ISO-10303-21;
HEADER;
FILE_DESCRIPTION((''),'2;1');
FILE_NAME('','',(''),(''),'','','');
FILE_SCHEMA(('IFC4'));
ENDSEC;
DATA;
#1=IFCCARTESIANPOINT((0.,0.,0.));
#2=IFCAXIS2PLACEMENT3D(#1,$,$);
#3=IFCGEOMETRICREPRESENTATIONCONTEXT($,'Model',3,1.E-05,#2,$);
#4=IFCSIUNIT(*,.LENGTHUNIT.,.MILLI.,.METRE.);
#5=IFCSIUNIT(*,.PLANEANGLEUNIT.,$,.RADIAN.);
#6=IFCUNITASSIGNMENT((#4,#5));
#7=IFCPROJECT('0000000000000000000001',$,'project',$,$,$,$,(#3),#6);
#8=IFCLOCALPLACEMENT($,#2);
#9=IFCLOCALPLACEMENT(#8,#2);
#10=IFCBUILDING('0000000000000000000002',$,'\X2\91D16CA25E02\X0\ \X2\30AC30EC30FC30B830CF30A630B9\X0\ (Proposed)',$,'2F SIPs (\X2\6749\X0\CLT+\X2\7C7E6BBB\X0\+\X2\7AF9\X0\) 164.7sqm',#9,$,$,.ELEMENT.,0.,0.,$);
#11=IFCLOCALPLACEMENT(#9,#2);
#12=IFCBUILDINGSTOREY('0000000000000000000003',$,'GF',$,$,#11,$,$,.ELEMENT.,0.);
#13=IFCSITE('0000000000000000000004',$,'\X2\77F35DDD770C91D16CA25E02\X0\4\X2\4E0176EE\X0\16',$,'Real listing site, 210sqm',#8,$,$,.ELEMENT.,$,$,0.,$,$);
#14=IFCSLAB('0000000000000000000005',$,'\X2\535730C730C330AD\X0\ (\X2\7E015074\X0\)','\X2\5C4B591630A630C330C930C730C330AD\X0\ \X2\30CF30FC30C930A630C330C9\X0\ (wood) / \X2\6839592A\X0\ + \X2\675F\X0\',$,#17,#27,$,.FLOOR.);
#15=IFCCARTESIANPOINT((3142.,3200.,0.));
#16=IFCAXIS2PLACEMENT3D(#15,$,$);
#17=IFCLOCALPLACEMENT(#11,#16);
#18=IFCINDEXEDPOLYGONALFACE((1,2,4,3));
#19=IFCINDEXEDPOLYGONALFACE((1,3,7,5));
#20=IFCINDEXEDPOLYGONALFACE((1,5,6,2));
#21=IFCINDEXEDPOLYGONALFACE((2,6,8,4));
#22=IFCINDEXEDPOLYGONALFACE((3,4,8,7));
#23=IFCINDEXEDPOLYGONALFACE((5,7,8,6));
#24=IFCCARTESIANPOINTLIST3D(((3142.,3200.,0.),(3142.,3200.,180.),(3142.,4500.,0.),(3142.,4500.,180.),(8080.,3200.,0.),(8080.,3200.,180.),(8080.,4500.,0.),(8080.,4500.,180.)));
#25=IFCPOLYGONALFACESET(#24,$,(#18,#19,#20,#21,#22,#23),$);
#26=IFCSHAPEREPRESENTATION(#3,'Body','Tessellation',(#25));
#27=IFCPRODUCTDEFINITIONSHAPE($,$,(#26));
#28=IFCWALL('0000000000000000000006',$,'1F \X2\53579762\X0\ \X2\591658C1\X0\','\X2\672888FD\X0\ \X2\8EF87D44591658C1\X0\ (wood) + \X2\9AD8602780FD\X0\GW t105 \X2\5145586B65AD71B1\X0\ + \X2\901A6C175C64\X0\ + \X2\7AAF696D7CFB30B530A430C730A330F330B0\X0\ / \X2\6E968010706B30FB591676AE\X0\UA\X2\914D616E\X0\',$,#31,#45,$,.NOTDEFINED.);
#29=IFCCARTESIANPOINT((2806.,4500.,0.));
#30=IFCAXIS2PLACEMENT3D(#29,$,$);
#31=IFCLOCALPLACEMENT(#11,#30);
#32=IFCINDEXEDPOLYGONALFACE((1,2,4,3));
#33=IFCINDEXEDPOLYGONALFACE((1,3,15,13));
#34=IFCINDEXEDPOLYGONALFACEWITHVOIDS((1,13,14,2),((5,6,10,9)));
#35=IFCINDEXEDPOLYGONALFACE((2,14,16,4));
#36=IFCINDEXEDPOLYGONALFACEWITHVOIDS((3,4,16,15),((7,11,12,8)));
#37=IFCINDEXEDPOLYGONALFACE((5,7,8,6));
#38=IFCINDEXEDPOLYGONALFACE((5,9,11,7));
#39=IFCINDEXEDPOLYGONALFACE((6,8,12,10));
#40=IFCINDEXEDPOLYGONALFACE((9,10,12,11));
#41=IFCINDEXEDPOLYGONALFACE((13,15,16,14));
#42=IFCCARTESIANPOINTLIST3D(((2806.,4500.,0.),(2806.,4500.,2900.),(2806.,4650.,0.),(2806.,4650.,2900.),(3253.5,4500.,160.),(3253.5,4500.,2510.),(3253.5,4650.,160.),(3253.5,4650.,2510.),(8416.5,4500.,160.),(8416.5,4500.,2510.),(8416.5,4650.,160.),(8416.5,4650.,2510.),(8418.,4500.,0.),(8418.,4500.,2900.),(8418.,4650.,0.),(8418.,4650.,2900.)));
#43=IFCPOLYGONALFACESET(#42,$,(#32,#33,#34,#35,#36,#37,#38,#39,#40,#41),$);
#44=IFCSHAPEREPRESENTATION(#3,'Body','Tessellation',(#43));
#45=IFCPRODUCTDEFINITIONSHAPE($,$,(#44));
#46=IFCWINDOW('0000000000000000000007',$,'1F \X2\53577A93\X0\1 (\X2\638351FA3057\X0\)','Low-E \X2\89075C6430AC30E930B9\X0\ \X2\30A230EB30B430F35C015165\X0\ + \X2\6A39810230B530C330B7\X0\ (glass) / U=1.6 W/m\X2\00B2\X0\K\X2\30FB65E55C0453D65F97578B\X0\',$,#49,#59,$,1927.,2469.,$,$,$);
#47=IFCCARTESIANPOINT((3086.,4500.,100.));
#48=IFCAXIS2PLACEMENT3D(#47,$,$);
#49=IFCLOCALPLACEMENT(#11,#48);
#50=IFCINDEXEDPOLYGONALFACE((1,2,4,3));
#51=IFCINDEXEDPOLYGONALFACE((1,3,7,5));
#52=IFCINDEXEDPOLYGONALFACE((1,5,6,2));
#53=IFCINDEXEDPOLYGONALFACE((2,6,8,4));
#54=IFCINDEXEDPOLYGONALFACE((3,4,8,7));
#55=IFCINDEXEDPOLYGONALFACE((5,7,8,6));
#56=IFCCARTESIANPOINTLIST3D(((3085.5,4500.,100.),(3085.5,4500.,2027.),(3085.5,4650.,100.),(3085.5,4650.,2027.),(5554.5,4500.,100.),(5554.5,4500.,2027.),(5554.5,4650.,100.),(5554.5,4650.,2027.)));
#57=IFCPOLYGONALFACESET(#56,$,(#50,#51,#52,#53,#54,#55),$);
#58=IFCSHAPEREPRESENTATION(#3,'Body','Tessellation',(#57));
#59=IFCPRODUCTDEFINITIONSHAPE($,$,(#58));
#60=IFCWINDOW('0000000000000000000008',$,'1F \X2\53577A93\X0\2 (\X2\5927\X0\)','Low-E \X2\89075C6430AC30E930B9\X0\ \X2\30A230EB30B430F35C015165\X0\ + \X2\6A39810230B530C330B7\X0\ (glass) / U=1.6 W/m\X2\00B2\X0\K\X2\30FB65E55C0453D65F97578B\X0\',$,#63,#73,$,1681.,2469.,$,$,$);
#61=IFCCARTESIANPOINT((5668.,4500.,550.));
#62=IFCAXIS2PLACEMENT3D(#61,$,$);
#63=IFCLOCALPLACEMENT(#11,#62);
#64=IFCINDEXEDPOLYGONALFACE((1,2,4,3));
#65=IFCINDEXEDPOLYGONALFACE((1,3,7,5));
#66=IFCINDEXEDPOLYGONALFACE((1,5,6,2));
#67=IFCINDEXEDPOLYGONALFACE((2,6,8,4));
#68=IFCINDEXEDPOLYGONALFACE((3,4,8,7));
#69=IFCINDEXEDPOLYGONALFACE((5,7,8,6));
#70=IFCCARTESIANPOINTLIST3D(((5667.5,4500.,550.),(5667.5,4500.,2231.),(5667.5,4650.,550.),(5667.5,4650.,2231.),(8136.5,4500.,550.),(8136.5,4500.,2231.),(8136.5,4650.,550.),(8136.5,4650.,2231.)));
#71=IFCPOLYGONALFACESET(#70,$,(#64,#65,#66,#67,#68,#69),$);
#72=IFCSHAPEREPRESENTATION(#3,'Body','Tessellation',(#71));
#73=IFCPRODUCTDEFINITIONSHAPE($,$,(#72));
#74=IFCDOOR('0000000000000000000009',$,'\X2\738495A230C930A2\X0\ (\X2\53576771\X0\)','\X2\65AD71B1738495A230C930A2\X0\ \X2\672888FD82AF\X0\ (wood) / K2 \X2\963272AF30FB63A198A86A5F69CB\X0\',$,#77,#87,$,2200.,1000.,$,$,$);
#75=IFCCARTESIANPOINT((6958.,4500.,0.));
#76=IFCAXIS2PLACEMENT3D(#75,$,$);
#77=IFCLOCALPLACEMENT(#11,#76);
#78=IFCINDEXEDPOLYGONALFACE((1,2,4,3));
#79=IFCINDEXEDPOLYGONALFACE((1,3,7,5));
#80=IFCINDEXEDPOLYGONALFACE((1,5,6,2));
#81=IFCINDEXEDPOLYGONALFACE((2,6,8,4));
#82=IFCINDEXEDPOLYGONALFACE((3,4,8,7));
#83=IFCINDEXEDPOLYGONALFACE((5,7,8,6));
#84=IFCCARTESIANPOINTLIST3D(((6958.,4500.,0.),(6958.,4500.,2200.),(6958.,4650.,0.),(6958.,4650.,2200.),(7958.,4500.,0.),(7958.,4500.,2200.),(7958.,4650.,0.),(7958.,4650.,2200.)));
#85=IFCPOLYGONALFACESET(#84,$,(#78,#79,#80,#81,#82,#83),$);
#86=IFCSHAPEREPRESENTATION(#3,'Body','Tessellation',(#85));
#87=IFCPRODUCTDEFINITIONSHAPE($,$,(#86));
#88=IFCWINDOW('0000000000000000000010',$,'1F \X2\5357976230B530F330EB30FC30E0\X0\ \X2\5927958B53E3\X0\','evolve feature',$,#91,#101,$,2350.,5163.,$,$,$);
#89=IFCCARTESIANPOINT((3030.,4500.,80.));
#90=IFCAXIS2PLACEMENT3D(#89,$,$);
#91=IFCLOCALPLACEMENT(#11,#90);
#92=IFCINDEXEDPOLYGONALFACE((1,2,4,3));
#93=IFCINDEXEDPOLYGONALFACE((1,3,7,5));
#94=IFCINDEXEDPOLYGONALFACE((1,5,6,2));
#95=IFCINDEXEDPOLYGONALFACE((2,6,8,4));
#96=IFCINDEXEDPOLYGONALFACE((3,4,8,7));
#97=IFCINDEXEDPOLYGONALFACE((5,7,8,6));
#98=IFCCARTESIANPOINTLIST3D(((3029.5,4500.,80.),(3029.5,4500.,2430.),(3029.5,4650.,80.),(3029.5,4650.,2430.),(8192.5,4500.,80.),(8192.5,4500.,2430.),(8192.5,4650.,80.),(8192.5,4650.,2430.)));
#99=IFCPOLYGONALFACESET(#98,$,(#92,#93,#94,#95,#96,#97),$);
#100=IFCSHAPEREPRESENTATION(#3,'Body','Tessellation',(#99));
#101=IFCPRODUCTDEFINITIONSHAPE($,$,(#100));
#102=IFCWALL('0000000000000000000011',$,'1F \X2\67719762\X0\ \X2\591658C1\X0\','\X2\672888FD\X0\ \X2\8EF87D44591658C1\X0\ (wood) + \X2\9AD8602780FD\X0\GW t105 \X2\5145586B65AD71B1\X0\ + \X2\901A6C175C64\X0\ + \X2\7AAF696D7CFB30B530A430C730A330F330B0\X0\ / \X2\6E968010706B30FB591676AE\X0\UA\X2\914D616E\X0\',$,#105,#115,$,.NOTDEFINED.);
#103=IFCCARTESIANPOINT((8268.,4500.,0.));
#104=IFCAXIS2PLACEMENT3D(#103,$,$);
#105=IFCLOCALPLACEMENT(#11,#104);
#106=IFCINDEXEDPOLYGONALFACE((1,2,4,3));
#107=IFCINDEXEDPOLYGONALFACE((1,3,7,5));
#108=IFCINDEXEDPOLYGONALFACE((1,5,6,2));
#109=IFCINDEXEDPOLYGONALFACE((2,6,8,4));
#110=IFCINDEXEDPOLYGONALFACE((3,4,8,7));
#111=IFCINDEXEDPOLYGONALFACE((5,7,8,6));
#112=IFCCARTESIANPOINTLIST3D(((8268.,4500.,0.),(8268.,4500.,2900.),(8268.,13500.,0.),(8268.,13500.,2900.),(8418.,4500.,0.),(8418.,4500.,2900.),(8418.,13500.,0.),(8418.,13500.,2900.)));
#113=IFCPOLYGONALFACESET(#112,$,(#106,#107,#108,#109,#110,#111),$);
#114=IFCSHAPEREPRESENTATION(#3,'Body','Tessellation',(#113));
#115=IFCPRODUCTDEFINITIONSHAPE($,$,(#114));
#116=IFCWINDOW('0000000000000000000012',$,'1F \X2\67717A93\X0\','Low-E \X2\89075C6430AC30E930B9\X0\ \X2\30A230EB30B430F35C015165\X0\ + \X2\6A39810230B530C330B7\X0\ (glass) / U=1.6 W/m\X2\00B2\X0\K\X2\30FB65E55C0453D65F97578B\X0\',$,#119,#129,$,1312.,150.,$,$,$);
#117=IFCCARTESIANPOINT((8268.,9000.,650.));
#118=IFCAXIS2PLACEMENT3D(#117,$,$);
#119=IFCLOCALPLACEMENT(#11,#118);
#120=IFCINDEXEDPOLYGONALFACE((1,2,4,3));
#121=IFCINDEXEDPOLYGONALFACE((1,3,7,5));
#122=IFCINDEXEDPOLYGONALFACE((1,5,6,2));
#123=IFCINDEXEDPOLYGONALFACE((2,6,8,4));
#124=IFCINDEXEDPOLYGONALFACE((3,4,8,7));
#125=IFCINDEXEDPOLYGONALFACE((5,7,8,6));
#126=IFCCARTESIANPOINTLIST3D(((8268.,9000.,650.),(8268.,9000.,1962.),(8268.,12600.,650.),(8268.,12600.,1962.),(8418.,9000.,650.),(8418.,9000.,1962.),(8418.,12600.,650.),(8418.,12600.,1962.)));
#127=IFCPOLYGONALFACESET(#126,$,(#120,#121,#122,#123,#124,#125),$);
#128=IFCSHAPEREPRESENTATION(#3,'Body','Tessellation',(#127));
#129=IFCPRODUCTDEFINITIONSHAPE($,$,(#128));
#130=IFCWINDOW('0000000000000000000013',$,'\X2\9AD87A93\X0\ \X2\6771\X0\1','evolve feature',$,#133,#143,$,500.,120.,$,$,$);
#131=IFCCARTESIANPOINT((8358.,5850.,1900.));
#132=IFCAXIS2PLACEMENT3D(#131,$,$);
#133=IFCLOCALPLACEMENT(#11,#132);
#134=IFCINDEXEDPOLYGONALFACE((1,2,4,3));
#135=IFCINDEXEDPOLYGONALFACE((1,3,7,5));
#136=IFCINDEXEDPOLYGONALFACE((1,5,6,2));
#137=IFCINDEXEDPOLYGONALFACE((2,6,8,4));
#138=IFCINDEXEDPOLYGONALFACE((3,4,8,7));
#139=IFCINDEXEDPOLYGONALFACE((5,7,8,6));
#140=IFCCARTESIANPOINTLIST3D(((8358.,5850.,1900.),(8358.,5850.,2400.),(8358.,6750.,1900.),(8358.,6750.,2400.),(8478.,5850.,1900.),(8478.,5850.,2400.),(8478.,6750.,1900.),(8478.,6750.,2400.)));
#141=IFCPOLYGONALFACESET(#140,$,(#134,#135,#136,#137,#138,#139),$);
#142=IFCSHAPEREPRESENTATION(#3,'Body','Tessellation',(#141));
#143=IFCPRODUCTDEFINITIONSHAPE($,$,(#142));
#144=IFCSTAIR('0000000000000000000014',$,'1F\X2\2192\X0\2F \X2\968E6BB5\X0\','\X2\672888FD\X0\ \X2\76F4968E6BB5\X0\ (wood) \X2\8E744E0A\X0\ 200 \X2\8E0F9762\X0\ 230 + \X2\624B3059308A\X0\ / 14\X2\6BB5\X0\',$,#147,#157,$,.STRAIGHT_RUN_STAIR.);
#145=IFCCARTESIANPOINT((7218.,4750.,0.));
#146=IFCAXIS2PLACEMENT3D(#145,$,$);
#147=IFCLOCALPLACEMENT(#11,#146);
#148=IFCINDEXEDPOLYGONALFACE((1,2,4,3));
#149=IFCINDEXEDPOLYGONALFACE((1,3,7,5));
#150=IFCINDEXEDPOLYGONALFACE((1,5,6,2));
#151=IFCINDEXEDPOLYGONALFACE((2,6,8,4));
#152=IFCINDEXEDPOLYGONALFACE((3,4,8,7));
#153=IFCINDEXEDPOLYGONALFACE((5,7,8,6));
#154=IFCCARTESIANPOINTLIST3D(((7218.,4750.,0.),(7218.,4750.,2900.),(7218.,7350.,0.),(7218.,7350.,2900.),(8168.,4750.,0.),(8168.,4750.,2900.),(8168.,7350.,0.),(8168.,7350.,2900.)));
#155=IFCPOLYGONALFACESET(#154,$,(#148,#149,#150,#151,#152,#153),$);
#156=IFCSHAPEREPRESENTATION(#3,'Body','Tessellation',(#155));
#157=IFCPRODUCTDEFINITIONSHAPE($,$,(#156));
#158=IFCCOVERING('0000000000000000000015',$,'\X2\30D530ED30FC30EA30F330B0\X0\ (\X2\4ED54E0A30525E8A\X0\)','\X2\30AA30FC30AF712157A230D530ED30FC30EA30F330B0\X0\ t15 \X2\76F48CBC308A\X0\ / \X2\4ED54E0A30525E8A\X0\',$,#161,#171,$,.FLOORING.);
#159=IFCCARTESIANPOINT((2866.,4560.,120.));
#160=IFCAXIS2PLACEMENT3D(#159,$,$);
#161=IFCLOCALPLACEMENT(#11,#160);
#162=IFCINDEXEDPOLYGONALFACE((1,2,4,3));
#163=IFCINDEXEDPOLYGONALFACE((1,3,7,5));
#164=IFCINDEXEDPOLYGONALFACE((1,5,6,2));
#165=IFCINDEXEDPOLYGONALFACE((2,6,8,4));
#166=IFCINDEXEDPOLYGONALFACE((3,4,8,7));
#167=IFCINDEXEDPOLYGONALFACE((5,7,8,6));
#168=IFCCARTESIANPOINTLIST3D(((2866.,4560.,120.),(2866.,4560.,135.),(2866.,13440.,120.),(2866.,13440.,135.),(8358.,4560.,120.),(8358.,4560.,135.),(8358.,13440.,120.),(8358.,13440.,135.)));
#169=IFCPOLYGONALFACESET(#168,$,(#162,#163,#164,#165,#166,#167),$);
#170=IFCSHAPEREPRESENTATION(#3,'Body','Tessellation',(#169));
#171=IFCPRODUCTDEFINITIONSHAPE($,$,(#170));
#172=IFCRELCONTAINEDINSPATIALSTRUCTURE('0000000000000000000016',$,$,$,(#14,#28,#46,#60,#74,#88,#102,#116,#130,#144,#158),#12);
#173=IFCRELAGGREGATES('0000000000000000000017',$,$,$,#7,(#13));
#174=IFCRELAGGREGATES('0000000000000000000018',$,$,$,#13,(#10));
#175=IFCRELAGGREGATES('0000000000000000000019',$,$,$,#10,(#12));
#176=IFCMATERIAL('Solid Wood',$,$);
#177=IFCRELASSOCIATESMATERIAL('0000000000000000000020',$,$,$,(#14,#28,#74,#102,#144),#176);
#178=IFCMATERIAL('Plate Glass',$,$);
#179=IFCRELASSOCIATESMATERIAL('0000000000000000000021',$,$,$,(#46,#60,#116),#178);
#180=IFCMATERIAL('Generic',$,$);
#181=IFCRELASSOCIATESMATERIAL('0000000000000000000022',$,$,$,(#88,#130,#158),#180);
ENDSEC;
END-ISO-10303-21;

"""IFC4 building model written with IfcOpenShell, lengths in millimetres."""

from ifc_helpers import new_model, si_unit, frame, frame_2d, origin, place, context, project, spatial, rectangle, extrude, material, element, fill, save


model = new_model("IFC4")

# Units and contexts
model_context = context("Model", 3, precision=1e-05, world=origin())
ifc_project = project(units=[si_unit("LENGTHUNIT", "METRE", prefix="MILLI"), si_unit("PLANEANGLEUNIT", "RADIAN")], contexts=[model_context])

# Site, building, storey
site_placement = place(None, origin())
site = spatial("IfcSite", under=ifc_project, at=site_placement, Name="石川県金沢市4丁目16", ObjectType="Real listing site, 210sqm", CompositionType="ELEMENT", RefElevation=0.0)
building_placement = place(site_placement, origin())
building = spatial("IfcBuilding", under=site, at=building_placement, Name="金沢市 ガレージハウス (Proposed)", ObjectType="2F SIPs (杉CLT+籾殻+竹) 164.7sqm", CompositionType="ELEMENT", ElevationOfRefHeight=0.0, ElevationOfTerrain=0.0)
storey_placement = place(building_placement, origin())
storey = spatial("IfcBuildingStorey", under=building, at=storey_placement, Name="GF", CompositionType="ELEMENT", Elevation=0.0)

# Slab
ifc_material_1 = material(Name="Solid Wood")
slab_1_placement = place(storey_placement, frame((3142.0, 3200.0, 0.0)))
element("IfcSlab", 1, at=slab_1_placement, inside=storey, material=ifc_material_1, Name="南デッキ (縁側)", Description="屋外ウッドデッキ ハードウッド (wood) / 根太 + 束", PredefinedType="FLOOR", context=model_context, shape_type="SweptSolid", body=[
    extrude(rectangle(XDim=4938.0, YDim=1300.0, at=frame_2d((2469.0, 650.0))), frame((3142.0, 3200.0, 0.0)), (0.0, 0.0, 1.0), 180.0),
])
ifc_material_2 = material(Name="Generic")

# Wall, openings, windows, door
wall_1_placement = place(storey_placement, frame((2806.0, 4500.0, 0.0)))
wall_1 = element("IfcWall", 2, at=wall_1_placement, inside=storey, material=ifc_material_1, Name="1F 南面 外壁", Description="木製 軸組外壁 (wood) + 高性能GW t105 充填断熱 + 通気層 + 窯業系サイディング / 準耐火・外皮UA配慮", PredefinedType="NOTDEFINED", context=model_context, shape_type="SweptSolid", body=[
    extrude(rectangle(XDim=5612.0, YDim=150.0, at=frame_2d((2806.0, 75.0))), frame((2806.0, 4500.0, 0.0)), (0.0, 0.0, 1.0), 2900.0),
])
opening_1_placement = place(storey_placement, frame((3086.0, 4500.0, 100.0)))
opening_1 = element("IfcOpeningElement", 3, at=opening_1_placement, cuts=wall_1, PredefinedType="NOTDEFINED", context=model_context, shape_type="SweptSolid", body=[
    extrude(rectangle(XDim=2469.0, YDim=150.0, at=frame_2d((1234.0, 75.0))), frame((3086.0, 4500.0, 100.0)), (0.0, 0.0, 1.0), 1927.0),
])
opening_2_placement = place(storey_placement, frame((5668.0, 4500.0, 550.0)))
opening_2 = element("IfcOpeningElement", 4, at=opening_2_placement, cuts=wall_1, PredefinedType="NOTDEFINED", context=model_context, shape_type="SweptSolid", body=[
    extrude(rectangle(XDim=2469.0, YDim=150.0, at=frame_2d((1234.0, 75.0))), frame((5668.0, 4500.0, 550.0)), (0.0, 0.0, 1.0), 1681.0),
])
opening_3_placement = place(storey_placement, frame((6958.0, 4500.0, 0.0)))
opening_3 = element("IfcOpeningElement", 5, at=opening_3_placement, cuts=wall_1, PredefinedType="NOTDEFINED", context=model_context, shape_type="SweptSolid", body=[
    extrude(rectangle(XDim=1000.0, YDim=150.0, at=frame_2d((500.0, 75.0))), frame((6958.0, 4500.0, 0.0)), (0.0, 0.0, 1.0), 2200.0),
])
opening_4_placement = place(storey_placement, frame((3030.0, 4500.0, 80.0)))
opening_4 = element("IfcOpeningElement", 6, at=opening_4_placement, cuts=wall_1, PredefinedType="NOTDEFINED", context=model_context, shape_type="SweptSolid", body=[
    extrude(rectangle(XDim=5163.0, YDim=150.0, at=frame_2d((2581.0, 75.0))), frame((3030.0, 4500.0, 80.0)), (0.0, 0.0, 1.0), 2350.0),
])
ifc_material_3 = material(Name="Plate Glass")
window_1_placement = place(storey_placement, frame((3086.0, 4500.0, 100.0)))
window_1 = element("IfcWindow", 7, at=window_1_placement, inside=storey, material=ifc_material_3, Name="1F 南窓1 (掃出し)", Description="Low-E 複層ガラス アルゴン封入 + 樹脂サッシ (glass) / U=1.6 W/m²K・日射取得型", OverallHeight=1927.0, OverallWidth=2469.0, context=model_context, shape_type="SweptSolid", body=[
    extrude(rectangle(XDim=2469.0, YDim=150.0, at=frame_2d((1234.0, 75.0))), frame((3086.0, 4500.0, 100.0)), (0.0, 0.0, 1.0), 1927.0),
])
fill(opening_1, window_1)
window_2_placement = place(storey_placement, frame((5668.0, 4500.0, 550.0)))
window_2 = element("IfcWindow", 8, at=window_2_placement, inside=storey, material=ifc_material_3, Name="1F 南窓2 (大)", Description="Low-E 複層ガラス アルゴン封入 + 樹脂サッシ (glass) / U=1.6 W/m²K・日射取得型", OverallHeight=1681.0, OverallWidth=2469.0, context=model_context, shape_type="SweptSolid", body=[
    extrude(rectangle(XDim=2469.0, YDim=150.0, at=frame_2d((1234.0, 75.0))), frame((5668.0, 4500.0, 550.0)), (0.0, 0.0, 1.0), 1681.0),
])
fill(opening_2, window_2)
door_placement = place(storey_placement, frame((6958.0, 4500.0, 0.0)))
door = element("IfcDoor", 9, at=door_placement, inside=storey, material=ifc_material_1, Name="玄関ドア (南東)", Description="断熱玄関ドア 木製芯 (wood) / K2 防犯・採風機構", OverallHeight=2200.0, OverallWidth=1000.0, context=model_context, shape_type="SweptSolid", body=[
    extrude(rectangle(XDim=1000.0, YDim=150.0, at=frame_2d((500.0, 75.0))), frame((6958.0, 4500.0, 0.0)), (0.0, 0.0, 1.0), 2200.0),
])
fill(opening_3, door)
window_3_placement = place(storey_placement, frame((3030.0, 4500.0, 80.0)))
window_3 = element("IfcWindow", 10, at=window_3_placement, inside=storey, material=ifc_material_2, Name="1F 南面サンルーム 大開口", Description="evolve feature", OverallHeight=2350.0, OverallWidth=5163.0, context=model_context, shape_type="SweptSolid", body=[
    extrude(rectangle(XDim=5163.0, YDim=150.0, at=frame_2d((2581.0, 75.0))), frame((3030.0, 4500.0, 80.0)), (0.0, 0.0, 1.0), 2350.0),
])
fill(opening_4, window_3)

# Wall, openings, windows
wall_2_placement = place(storey_placement, frame((8268.0, 4500.0, 0.0)))
wall_2 = element("IfcWall", 11, at=wall_2_placement, inside=storey, material=ifc_material_1, Name="1F 東面 外壁", Description="木製 軸組外壁 (wood) + 高性能GW t105 充填断熱 + 通気層 + 窯業系サイディング / 準耐火・外皮UA配慮", PredefinedType="NOTDEFINED", context=model_context, shape_type="SweptSolid", body=[
    extrude(rectangle(XDim=150.0, YDim=9000.0, at=frame_2d((75.0, 4500.0))), frame((8268.0, 4500.0, 0.0)), (0.0, 0.0, 1.0), 2900.0),
])
opening_5_placement = place(storey_placement, frame((8268.0, 9000.0, 650.0)))
opening_5 = element("IfcOpeningElement", 12, at=opening_5_placement, cuts=wall_2, PredefinedType="NOTDEFINED", context=model_context, shape_type="SweptSolid", body=[
    extrude(rectangle(XDim=150.0, YDim=3600.0, at=frame_2d((75.0, 1800.0))), frame((8268.0, 9000.0, 650.0)), (0.0, 0.0, 1.0), 1312.0),
])
opening_6_placement = place(storey_placement, frame((8358.0, 5850.0, 1900.0)))
opening_6 = element("IfcOpeningElement", 13, at=opening_6_placement, cuts=wall_2, PredefinedType="NOTDEFINED", context=model_context, shape_type="SweptSolid", body=[
    extrude(rectangle(XDim=120.0, YDim=900.0, at=frame_2d((60.0, 450.0))), frame((8358.0, 5850.0, 1900.0)), (0.0, 0.0, 1.0), 500.0),
])
window_4_placement = place(storey_placement, frame((8268.0, 9000.0, 650.0)))
window_4 = element("IfcWindow", 14, at=window_4_placement, inside=storey, material=ifc_material_3, Name="1F 東窓", Description="Low-E 複層ガラス アルゴン封入 + 樹脂サッシ (glass) / U=1.6 W/m²K・日射取得型", OverallHeight=1312.0, OverallWidth=150.0, context=model_context, shape_type="SweptSolid", body=[
    extrude(rectangle(XDim=150.0, YDim=3600.0, at=frame_2d((75.0, 1800.0))), frame((8268.0, 9000.0, 650.0)), (0.0, 0.0, 1.0), 1312.0),
])
fill(opening_5, window_4)
window_5_placement = place(storey_placement, frame((8358.0, 5850.0, 1900.0)))
window_5 = element("IfcWindow", 15, at=window_5_placement, inside=storey, material=ifc_material_2, Name="高窓 東1", Description="evolve feature", OverallHeight=500.0, OverallWidth=120.0, context=model_context, shape_type="SweptSolid", body=[
    extrude(rectangle(XDim=120.0, YDim=900.0, at=frame_2d((60.0, 450.0))), frame((8358.0, 5850.0, 1900.0)), (0.0, 0.0, 1.0), 500.0),
])
fill(opening_6, window_5)

# Stair
stair_placement = place(storey_placement, frame((7218.0, 4750.0, 0.0)))
element("IfcStair", 16, at=stair_placement, inside=storey, material=ifc_material_1, Name="1F→2F 階段", Description="木製 直階段 (wood) 蹴上 200 踏面 230 + 手すり / 14段", PredefinedType="STRAIGHT_RUN_STAIR", context=model_context, shape_type="SweptSolid", body=[
    extrude(rectangle(XDim=950.0, YDim=2600.0, at=frame_2d((475.0, 1300.0))), frame((7218.0, 4750.0, 0.0)), (0.0, 0.0, 1.0), 2900.0),
])

# Covering
covering_placement = place(storey_placement, frame((2866.0, 4560.0, 120.0)))
element("IfcCovering", 17, at=covering_placement, inside=storey, material=ifc_material_2, Name="フローリング (仕上げ床)", Description="オーク無垢フローリング t15 直貼り / 仕上げ床", PredefinedType="FLOORING", context=model_context, shape_type="SweptSolid", body=[
    extrude(rectangle(XDim=5492.0, YDim=8880.0, at=frame_2d((2746.0, 4440.0))), frame((2866.0, 4560.0, 120.0)), (0.0, 0.0, 1.0), 15.0),
])

save(model, "model.ifc")
